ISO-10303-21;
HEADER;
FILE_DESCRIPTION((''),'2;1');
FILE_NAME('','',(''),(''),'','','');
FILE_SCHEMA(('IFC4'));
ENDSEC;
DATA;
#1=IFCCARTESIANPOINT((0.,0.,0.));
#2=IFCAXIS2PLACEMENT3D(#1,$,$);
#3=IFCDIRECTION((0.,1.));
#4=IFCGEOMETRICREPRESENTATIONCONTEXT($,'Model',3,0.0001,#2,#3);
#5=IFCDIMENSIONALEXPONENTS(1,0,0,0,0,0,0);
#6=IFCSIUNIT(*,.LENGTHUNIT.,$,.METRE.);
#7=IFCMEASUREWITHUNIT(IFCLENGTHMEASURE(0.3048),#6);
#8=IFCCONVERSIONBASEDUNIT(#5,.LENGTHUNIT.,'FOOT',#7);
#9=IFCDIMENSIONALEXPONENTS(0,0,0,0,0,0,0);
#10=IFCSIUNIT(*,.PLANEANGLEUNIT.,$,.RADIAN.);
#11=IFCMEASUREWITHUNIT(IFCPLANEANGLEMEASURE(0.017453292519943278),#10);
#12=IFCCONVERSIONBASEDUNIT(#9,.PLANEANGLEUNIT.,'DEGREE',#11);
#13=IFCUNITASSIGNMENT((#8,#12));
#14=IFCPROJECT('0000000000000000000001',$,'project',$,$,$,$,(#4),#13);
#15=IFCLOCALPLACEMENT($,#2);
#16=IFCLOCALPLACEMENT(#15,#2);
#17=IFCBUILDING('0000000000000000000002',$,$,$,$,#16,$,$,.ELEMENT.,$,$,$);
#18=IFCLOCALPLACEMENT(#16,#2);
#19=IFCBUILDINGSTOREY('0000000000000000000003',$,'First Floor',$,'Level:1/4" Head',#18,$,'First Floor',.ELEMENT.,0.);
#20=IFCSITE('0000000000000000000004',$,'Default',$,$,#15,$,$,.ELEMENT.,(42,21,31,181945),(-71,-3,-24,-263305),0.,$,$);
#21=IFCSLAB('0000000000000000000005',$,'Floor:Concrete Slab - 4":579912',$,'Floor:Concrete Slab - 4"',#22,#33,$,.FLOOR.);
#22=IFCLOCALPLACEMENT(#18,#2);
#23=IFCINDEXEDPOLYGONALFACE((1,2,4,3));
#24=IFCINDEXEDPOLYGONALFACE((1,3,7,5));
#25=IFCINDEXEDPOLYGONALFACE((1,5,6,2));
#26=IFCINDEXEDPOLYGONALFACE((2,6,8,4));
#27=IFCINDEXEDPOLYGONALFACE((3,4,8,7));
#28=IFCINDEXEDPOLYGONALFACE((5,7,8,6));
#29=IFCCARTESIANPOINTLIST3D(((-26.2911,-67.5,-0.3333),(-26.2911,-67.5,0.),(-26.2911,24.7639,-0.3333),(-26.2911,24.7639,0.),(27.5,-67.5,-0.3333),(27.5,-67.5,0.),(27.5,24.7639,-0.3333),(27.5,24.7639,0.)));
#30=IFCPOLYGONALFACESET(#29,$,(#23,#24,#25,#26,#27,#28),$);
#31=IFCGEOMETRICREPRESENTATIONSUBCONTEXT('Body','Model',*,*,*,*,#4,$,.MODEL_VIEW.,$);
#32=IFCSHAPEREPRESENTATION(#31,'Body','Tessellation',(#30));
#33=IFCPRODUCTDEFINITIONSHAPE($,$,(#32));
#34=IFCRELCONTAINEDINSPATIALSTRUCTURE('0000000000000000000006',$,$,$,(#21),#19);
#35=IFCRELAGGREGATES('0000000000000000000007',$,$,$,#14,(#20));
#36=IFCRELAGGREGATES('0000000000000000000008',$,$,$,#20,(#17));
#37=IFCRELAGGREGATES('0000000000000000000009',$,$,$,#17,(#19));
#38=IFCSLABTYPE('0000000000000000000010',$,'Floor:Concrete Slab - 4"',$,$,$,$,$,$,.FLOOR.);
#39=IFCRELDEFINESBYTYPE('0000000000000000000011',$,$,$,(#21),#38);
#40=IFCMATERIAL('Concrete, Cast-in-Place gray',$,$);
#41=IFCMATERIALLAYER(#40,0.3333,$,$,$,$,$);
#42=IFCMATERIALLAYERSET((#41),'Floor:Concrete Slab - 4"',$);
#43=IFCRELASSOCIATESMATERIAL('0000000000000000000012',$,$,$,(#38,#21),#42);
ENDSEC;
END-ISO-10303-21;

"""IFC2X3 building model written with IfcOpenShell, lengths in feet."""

from ifc_helpers import new_model, entity, si_unit, converted_unit, direction, frame, frame_2d, origin, place, context, subcontext, project, spatial, rectangle, extrude, material, layer, layer_set, layer_usage, type_object, element, save


model = new_model("IFC2X3")

# Units and contexts
model_context = context("Model", 3, precision=0.0001, world=origin(), true_north=direction((0.0, 1.0)))
body_context = subcontext(model_context, "Body", "Model", "MODEL_VIEW")
ifc_project = project(units=[converted_unit("LENGTHUNIT", "FOOT", entity("IfcLengthMeasure", 0.3048), si_unit("LENGTHUNIT", "METRE"), dimensions=[1, 0, 0, 0, 0, 0, 0]), converted_unit("PLANEANGLEUNIT", "DEGREE", entity("IfcPlaneAngleMeasure", 0.017453292519943278), si_unit("PLANEANGLEUNIT", "RADIAN"), dimensions=[0, 0, 0, 0, 0, 0, 0])], contexts=[model_context])

# Site, building, storey
site_placement = place(None, origin())
site = spatial("IfcSite", under=ifc_project, at=site_placement, Name="Default", CompositionType="ELEMENT", RefLatitude=(42, 21, 31, 181945), RefLongitude=(-71, -3, -24, -263305), RefElevation=0.0)
building_placement = place(site_placement, origin())
building = spatial("IfcBuilding", under=site, at=building_placement, CompositionType="ELEMENT")
storey_placement = place(building_placement, origin())
storey = spatial("IfcBuildingStorey", under=building, at=storey_placement, Name="First Floor", ObjectType="Level:1/4\" Head", LongName="First Floor", CompositionType="ELEMENT", Elevation=0.0)

# Slab
ifc_material_1 = material(Name="Concrete, Cast-in-Place gray")
ifc_layer_1 = layer(ifc_material_1, 0.3333)
ifc_layer_set_1 = layer_set([ifc_layer_1], Name="Floor:Concrete Slab - 4\"")
ifc_layer_usage_1 = layer_usage(ifc_layer_set_1, "AXIS3", "POSITIVE", 0.0)
slab_type = type_object("IfcSlabType", Name="Floor:Concrete Slab - 4\"", PredefinedType="FLOOR", material=ifc_layer_set_1)
slab_placement = place(storey_placement, origin())
element("IfcSlab", 1, at=slab_placement, inside=storey, type_object=slab_type, material=ifc_layer_usage_1, Name="Floor:Concrete Slab - 4\":579912", ObjectType="Floor:Concrete Slab - 4\"", PredefinedType="FLOOR", context=body_context, shape_type="SweptSolid", body=[
    extrude(rectangle(XDim=92.2639, YDim=53.7911, at=frame_2d((0.0, 0.0), x_axis=(1.0, 0.0))), frame((0.6045, -21.3681, 0.0), z_axis=(0.0, 0.0, -1.0), x_axis=(0.0, 1.0, 0.0)), (0.0, 0.0, 1.0), 0.3333),
])

save(model, "model.ifc")
